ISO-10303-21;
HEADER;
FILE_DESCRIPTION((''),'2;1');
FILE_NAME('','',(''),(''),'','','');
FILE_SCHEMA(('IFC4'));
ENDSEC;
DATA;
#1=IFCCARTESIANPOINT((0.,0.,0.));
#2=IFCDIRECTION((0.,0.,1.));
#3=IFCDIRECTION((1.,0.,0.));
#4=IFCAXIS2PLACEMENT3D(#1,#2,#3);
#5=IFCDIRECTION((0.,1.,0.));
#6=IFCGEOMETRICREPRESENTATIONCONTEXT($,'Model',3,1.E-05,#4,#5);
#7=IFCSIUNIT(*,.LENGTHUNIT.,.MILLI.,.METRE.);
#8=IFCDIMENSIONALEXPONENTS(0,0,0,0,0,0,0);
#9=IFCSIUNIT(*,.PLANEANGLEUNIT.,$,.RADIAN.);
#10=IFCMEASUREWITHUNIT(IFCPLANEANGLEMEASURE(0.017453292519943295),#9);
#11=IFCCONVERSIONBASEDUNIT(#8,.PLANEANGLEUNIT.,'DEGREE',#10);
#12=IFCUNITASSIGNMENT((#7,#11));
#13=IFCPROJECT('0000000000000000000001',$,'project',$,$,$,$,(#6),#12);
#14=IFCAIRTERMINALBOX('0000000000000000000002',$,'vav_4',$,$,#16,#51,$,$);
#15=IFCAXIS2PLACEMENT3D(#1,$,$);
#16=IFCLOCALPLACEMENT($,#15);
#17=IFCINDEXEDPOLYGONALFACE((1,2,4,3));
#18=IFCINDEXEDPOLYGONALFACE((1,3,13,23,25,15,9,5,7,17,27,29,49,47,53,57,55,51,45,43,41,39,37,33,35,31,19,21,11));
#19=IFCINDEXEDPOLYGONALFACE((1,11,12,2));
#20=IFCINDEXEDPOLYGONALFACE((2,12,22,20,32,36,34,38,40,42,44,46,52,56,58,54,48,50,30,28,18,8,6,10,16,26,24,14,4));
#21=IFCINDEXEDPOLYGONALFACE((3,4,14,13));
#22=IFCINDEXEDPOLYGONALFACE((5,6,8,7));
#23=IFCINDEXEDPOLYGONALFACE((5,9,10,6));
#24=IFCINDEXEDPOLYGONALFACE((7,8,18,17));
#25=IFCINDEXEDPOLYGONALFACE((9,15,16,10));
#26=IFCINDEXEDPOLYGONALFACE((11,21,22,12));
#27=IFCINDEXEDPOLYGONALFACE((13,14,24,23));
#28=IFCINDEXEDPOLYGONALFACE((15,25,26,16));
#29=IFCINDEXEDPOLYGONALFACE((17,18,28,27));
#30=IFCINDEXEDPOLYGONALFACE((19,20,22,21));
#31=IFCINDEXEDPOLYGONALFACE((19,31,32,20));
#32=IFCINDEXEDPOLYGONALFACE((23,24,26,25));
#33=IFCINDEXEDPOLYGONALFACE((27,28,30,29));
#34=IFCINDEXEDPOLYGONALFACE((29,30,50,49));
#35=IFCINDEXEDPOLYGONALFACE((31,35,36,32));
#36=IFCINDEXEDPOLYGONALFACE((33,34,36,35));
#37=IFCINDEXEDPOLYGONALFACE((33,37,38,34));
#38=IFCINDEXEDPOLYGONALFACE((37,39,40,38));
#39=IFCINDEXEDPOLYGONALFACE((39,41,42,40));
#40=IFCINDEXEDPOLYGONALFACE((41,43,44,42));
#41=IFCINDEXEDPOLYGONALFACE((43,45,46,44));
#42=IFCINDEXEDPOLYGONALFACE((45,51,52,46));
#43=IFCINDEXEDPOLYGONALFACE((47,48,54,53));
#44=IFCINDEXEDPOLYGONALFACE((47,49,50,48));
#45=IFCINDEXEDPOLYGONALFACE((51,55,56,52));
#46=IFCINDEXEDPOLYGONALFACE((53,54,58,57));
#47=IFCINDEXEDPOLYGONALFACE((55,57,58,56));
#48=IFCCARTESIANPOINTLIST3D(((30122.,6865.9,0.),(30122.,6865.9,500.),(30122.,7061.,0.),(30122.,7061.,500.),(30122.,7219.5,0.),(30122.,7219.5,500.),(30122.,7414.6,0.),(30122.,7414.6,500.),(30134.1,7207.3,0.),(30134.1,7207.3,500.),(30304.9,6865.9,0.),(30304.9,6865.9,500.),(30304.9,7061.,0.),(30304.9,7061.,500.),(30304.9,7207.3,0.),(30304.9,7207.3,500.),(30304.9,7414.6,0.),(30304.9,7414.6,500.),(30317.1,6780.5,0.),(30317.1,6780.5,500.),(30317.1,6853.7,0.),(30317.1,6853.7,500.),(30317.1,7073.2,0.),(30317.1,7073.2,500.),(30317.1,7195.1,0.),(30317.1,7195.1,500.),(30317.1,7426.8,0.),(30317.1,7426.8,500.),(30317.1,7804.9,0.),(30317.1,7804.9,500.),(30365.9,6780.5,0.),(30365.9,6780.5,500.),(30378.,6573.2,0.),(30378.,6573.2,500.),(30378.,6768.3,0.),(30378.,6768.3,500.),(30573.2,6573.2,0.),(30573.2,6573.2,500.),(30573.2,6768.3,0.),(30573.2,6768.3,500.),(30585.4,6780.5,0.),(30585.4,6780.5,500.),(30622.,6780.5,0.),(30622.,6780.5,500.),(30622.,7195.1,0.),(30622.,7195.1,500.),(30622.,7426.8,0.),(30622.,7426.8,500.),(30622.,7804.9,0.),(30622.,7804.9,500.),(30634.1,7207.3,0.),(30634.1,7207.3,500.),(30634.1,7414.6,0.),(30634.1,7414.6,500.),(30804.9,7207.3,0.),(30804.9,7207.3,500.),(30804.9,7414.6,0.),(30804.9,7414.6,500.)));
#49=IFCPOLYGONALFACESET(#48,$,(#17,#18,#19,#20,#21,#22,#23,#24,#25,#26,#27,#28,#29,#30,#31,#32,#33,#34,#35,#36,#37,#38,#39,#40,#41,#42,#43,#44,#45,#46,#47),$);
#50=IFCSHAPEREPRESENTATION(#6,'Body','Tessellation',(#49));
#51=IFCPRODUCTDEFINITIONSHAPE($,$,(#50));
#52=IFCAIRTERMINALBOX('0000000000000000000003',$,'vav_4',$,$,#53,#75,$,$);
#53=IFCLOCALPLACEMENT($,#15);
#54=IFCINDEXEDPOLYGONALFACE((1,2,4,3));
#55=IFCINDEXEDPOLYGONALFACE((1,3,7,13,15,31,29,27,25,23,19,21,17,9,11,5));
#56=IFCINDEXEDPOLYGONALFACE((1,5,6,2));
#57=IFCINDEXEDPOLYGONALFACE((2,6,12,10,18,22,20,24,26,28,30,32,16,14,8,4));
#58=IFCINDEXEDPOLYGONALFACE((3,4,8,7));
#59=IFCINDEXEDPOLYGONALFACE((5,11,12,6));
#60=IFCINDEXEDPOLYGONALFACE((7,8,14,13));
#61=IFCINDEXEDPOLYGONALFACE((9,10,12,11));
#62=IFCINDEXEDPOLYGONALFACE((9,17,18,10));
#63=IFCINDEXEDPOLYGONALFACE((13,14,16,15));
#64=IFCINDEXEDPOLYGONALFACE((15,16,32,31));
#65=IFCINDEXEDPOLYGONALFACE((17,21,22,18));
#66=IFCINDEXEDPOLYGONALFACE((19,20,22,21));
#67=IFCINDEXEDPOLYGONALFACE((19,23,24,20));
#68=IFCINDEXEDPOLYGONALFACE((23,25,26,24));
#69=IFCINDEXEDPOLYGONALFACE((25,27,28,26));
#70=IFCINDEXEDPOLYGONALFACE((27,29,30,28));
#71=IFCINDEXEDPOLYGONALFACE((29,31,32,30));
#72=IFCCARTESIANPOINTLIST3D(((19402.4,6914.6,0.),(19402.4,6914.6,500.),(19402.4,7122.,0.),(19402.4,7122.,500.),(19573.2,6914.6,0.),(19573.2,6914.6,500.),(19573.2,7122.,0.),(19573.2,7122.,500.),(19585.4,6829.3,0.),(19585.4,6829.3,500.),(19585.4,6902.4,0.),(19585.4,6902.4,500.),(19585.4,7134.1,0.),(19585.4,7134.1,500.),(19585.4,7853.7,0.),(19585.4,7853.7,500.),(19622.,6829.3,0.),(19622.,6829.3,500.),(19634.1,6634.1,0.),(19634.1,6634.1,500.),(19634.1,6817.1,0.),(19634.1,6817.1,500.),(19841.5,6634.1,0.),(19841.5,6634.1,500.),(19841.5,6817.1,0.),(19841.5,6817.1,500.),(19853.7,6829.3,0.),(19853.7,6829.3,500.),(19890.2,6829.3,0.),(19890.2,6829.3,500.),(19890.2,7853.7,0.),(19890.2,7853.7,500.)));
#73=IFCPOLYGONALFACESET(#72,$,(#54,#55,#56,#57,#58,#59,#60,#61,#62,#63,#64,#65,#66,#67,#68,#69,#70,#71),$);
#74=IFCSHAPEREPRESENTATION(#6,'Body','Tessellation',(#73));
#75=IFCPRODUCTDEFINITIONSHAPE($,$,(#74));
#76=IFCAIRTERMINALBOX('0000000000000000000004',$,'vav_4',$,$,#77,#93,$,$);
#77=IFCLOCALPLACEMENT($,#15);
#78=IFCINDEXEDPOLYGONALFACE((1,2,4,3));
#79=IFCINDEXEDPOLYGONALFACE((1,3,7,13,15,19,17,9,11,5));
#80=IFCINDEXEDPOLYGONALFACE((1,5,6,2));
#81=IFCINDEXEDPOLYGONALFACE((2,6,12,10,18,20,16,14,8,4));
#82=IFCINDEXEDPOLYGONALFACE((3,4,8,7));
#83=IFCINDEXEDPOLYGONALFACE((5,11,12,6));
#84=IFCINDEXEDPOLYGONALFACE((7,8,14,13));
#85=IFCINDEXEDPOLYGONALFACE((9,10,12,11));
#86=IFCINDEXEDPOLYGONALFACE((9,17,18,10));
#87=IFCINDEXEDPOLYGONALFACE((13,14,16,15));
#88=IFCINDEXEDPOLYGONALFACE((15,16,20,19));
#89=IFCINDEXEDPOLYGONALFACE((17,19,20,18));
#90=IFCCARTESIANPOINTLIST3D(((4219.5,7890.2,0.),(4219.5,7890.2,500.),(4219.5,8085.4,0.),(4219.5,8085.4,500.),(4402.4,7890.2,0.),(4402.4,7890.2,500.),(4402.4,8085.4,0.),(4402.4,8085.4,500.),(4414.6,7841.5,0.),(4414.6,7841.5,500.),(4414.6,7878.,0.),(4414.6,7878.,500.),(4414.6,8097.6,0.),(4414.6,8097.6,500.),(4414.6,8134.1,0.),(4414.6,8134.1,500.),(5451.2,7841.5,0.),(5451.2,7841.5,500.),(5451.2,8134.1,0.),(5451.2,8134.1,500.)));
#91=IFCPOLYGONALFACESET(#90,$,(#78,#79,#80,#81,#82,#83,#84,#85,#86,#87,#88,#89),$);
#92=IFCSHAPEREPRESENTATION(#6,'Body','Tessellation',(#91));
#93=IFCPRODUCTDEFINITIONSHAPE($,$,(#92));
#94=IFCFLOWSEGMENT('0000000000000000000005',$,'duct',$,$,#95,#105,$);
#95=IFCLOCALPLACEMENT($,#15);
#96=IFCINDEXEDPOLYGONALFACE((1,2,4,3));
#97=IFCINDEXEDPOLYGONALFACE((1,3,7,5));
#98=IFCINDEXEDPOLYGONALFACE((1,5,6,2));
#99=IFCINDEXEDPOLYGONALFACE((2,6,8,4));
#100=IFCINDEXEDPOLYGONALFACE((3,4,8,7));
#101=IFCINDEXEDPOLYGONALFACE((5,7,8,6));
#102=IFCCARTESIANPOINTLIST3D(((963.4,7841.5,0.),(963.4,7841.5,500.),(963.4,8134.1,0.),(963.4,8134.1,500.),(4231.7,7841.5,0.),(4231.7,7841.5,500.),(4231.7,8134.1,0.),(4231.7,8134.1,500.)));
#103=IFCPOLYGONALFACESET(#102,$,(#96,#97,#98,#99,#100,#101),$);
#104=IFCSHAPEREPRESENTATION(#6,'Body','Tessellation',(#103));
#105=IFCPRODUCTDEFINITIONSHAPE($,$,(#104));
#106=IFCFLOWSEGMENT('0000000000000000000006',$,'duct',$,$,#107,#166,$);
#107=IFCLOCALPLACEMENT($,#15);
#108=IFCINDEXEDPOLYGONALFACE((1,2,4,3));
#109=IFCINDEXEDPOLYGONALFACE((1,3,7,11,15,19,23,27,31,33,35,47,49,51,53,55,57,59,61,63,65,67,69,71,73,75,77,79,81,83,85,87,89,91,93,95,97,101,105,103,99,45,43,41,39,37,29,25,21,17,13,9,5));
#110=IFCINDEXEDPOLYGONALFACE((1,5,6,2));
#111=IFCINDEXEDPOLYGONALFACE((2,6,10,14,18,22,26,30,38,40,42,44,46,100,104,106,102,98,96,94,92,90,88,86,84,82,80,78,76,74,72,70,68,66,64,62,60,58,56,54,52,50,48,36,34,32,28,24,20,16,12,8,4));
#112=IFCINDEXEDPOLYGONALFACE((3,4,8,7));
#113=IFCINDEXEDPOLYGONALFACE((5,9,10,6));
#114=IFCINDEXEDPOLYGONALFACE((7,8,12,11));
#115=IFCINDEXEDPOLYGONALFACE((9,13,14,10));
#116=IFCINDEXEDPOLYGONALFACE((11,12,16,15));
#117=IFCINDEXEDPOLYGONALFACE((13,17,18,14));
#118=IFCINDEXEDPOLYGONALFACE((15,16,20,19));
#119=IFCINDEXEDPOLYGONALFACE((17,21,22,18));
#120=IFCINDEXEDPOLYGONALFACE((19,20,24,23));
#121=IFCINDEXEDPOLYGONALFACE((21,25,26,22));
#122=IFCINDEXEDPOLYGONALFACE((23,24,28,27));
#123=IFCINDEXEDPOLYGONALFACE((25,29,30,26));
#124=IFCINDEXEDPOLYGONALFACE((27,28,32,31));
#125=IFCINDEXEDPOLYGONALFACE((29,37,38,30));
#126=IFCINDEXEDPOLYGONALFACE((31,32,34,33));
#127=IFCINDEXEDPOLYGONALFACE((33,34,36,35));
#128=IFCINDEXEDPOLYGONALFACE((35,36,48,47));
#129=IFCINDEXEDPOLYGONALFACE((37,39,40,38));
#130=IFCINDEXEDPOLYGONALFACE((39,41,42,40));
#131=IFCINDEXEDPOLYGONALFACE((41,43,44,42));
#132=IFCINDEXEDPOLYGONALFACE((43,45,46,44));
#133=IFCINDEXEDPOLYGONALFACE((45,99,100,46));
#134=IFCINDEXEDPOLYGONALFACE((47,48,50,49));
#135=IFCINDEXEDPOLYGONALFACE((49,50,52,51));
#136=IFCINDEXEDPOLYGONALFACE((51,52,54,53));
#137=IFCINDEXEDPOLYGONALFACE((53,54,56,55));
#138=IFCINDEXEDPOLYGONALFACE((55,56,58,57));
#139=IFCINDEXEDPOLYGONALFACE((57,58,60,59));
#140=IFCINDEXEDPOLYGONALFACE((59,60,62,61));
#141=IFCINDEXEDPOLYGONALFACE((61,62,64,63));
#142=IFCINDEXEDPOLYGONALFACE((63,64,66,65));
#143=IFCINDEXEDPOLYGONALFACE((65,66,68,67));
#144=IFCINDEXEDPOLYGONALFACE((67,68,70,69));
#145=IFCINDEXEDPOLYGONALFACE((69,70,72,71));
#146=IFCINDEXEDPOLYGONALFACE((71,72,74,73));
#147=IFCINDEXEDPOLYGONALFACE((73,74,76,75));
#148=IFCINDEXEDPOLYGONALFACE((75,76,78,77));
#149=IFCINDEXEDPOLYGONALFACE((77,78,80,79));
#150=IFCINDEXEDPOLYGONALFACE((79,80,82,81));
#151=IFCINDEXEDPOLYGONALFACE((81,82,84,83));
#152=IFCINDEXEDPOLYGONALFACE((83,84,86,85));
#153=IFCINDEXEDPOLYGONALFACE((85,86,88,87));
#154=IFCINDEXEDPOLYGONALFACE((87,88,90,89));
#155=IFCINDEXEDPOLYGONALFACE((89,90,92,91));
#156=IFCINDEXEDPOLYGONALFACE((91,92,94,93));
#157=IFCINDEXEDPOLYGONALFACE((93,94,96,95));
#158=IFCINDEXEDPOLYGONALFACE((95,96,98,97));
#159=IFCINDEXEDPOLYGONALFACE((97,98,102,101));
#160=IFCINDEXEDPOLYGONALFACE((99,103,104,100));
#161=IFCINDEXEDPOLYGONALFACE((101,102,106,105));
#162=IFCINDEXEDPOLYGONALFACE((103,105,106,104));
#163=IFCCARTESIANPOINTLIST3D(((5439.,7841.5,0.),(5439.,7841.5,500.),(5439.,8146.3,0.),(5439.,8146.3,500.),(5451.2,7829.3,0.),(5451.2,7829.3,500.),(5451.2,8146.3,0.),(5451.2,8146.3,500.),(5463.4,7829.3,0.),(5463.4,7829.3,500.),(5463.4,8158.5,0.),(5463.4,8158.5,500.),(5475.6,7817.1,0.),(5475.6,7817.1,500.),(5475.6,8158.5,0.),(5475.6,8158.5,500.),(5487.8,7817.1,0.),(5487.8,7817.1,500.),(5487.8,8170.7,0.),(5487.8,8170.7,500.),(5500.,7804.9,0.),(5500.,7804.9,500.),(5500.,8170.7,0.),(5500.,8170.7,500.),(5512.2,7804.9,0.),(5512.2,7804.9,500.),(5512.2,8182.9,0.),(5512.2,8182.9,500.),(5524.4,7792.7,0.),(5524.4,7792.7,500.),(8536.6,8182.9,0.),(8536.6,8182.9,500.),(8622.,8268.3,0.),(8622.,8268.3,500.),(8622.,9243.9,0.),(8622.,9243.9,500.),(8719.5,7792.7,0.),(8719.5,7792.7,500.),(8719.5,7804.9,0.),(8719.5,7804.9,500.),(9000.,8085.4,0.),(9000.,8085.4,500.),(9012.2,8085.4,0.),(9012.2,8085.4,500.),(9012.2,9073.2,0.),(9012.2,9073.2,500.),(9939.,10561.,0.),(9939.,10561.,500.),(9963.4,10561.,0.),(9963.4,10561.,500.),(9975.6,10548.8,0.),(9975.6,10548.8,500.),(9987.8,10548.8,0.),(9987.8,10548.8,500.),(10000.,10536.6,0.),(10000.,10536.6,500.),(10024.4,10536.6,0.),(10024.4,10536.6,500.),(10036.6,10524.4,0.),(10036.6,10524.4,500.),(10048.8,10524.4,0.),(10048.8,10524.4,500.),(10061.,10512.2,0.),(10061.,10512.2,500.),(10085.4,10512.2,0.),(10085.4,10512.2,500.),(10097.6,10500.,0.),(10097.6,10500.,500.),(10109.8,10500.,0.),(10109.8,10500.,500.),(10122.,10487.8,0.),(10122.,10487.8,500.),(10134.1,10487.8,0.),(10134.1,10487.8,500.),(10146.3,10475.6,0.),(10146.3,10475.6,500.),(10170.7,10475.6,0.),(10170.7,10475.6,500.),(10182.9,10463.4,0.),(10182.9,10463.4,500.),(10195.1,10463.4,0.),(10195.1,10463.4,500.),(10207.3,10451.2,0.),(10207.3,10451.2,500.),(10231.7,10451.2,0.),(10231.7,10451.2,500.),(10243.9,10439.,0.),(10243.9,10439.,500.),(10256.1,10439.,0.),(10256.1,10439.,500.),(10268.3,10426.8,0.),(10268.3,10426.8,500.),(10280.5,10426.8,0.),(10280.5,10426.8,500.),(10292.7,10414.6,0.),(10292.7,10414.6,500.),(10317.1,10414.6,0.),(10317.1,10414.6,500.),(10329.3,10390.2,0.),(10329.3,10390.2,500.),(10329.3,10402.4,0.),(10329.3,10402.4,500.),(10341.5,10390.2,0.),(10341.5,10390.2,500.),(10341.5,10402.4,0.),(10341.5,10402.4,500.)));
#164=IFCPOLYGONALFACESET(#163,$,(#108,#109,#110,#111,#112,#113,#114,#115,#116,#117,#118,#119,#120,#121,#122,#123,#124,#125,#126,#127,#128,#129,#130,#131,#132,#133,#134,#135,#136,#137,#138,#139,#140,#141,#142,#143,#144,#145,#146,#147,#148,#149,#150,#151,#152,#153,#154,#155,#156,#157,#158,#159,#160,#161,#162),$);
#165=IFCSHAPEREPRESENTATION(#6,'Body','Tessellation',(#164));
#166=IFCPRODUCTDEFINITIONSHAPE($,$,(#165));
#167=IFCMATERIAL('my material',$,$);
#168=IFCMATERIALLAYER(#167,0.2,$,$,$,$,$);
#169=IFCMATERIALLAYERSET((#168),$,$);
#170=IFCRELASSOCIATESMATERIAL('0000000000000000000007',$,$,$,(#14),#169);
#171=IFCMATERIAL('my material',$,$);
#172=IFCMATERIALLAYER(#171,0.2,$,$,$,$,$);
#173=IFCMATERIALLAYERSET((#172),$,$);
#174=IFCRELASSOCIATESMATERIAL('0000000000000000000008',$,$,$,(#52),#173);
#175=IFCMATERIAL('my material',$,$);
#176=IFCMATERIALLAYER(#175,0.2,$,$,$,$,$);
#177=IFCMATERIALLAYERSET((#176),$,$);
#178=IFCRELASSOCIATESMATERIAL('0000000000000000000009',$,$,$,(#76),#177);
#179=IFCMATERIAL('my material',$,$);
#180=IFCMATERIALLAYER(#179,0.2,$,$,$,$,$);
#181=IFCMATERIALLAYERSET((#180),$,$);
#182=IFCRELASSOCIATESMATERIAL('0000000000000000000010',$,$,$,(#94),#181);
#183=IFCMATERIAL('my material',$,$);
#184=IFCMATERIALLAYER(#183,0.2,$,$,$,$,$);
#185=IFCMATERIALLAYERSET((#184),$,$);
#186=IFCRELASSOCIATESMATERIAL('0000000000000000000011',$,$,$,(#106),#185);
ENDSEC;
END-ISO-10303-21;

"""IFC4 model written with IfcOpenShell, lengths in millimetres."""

from ifc_helpers import new_model, entity, si_unit, converted_unit, direction, origin_with_axes, place, context, project, polyline, outline, extrude, material, layer, layer_set, layer_usage, element, save


model = new_model("IFC4")

# Units and contexts
model_context = context("Model", 3, precision=1e-05, world=origin_with_axes(), true_north=direction((0.0, 1.0, 0.0)))
ifc_project = project(units=[si_unit("LENGTHUNIT", "METRE", prefix="MILLI"), converted_unit("PLANEANGLEUNIT", "DEGREE", entity("IfcPlaneAngleMeasure", 0.017453292519943295), si_unit("PLANEANGLEUNIT", "RADIAN"), dimensions=[0, 0, 0, 0, 0, 0, 0])], contexts=[model_context])

# Air terminal boxes
ifc_material_1 = material(Name="my material")
ifc_layer_1 = layer(ifc_material_1, 0.2)
ifc_layer_set_1 = layer_set([ifc_layer_1])
ifc_layer_usage_1 = layer_usage(ifc_layer_set_1, "AXIS2", "POSITIVE", -0.1)
air_terminal_box_1_placement = place(None, origin_with_axes())
element("IfcAirTerminalBox", 1, at=air_terminal_box_1_placement, material=ifc_layer_usage_1, Name="vav_4", context=model_context, shape_type="SweptSolid", body=[
    extrude(outline(polyline([(30122.0, 6865.9), (30304.9, 6865.9), (30317.1, 6853.7), (30317.1, 6780.5), (30365.9, 6780.5), (30378.0, 6768.3), (30378.0, 6573.2), (30573.2, 6573.2), (30573.2, 6768.3), (30585.4, 6780.5), (30622.0, 6780.5), (30622.0, 7195.1), (30634.1, 7207.3), (30804.9, 7207.3), (30804.9, 7414.6), (30634.1, 7414.6), (30622.0, 7426.8), (30622.0, 7804.9), (30317.1, 7804.9), (30317.1, 7426.8), (30304.9, 7414.6), (30122.0, 7414.6), (30122.0, 7219.5), (30134.1, 7207.3), (30304.9, 7207.3), (30317.1, 7195.1), (30317.1, 7073.2), (30304.9, 7061.0), (30122.0, 7061.0), (30122.0, 6865.9)])), origin_with_axes(), (0.0, 0.0, 1.0), 500.0),
])
ifc_material_2 = material(Name="my material")
ifc_layer_2 = layer(ifc_material_2, 0.2)
ifc_layer_set_2 = layer_set([ifc_layer_2])
ifc_layer_usage_2 = layer_usage(ifc_layer_set_2, "AXIS2", "POSITIVE", -0.1)
air_terminal_box_2_placement = place(None, origin_with_axes())
element("IfcAirTerminalBox", 2, at=air_terminal_box_2_placement, material=ifc_layer_usage_2, Name="vav_4", context=model_context, shape_type="SweptSolid", body=[
    extrude(outline(polyline([(19402.4, 6914.6), (19573.2, 6914.6), (19585.4, 6902.4), (19585.4, 6829.3), (19622.0, 6829.3), (19634.1, 6817.1), (19634.1, 6634.1), (19841.5, 6634.1), (19841.5, 6817.1), (19853.7, 6829.3), (19890.2, 6829.3), (19890.2, 7853.7), (19585.4, 7853.7), (19585.4, 7134.1), (19573.2, 7122.0), (19402.4, 7122.0), (19402.4, 6914.6)])), origin_with_axes(), (0.0, 0.0, 1.0), 500.0),
])
ifc_material_3 = material(Name="my material")
ifc_layer_3 = layer(ifc_material_3, 0.2)
ifc_layer_set_3 = layer_set([ifc_layer_3])
ifc_layer_usage_3 = layer_usage(ifc_layer_set_3, "AXIS2", "POSITIVE", -0.1)
air_terminal_box_3_placement = place(None, origin_with_axes())
element("IfcAirTerminalBox", 3, at=air_terminal_box_3_placement, material=ifc_layer_usage_3, Name="vav_4", context=model_context, shape_type="SweptSolid", body=[
    extrude(outline(polyline([(4219.5, 7890.2), (4402.4, 7890.2), (4414.6, 7878.0), (4414.6, 7841.5), (5451.2, 7841.5), (5451.2, 8134.1), (4414.6, 8134.1), (4414.6, 8097.6), (4402.4, 8085.4), (4219.5, 8085.4), (4219.5, 7890.2)])), origin_with_axes(), (0.0, 0.0, 1.0), 500.0),
])

# Flow segments
ifc_material_4 = material(Name="my material")
ifc_layer_4 = layer(ifc_material_4, 0.2)
ifc_layer_set_4 = layer_set([ifc_layer_4])
ifc_layer_usage_4 = layer_usage(ifc_layer_set_4, "AXIS2", "POSITIVE", -0.1)
flow_segment_1_placement = place(None, origin_with_axes())
element("IfcFlowSegment", 4, at=flow_segment_1_placement, material=ifc_layer_usage_4, Name="duct", context=model_context, shape_type="SweptSolid", body=[
    extrude(outline(polyline([(963.4, 7841.5), (4231.7, 7841.5), (4231.7, 8134.1), (963.4, 8134.1), (963.4, 7841.5)])), origin_with_axes(), (0.0, 0.0, 1.0), 500.0),
])
ifc_material_5 = material(Name="my material")
ifc_layer_5 = layer(ifc_material_5, 0.2)
ifc_layer_set_5 = layer_set([ifc_layer_5])
ifc_layer_usage_5 = layer_usage(ifc_layer_set_5, "AXIS2", "POSITIVE", -0.1)
flow_segment_2_placement = place(None, origin_with_axes())
element("IfcFlowSegment", 5, at=flow_segment_2_placement, material=ifc_layer_usage_5, Name="duct", context=model_context, shape_type="SweptSolid", body=[
    extrude(outline(polyline([(5439.0, 7841.5), (5451.2, 7829.3), (5463.4, 7829.3), (5475.6, 7817.1), (5487.8, 7817.1), (5500.0, 7804.9), (5512.2, 7804.9), (5524.4, 7792.7), (8719.5, 7792.7), (8719.5, 7804.9), (9000.0, 8085.4), (9012.2, 8085.4), (9012.2, 9073.2), (10329.3, 10390.2), (10341.5, 10390.2), (10341.5, 10402.4), (10329.3, 10402.4), (10317.1, 10414.6), (10292.7, 10414.6), (10280.5, 10426.8), (10268.3, 10426.8), (10256.1, 10439.0), (10243.9, 10439.0), (10231.7, 10451.2), (10207.3, 10451.2), (10195.1, 10463.4), (10182.9, 10463.4), (10170.7, 10475.6), (10146.3, 10475.6), (10134.1, 10487.8), (10122.0, 10487.8), (10109.8, 10500.0), (10097.6, 10500.0), (10085.4, 10512.2), (10061.0, 10512.2), (10048.8, 10524.4), (10036.6, 10524.4), (10024.4, 10536.6), (10000.0, 10536.6), (9987.8, 10548.8), (9975.6, 10548.8), (9963.4, 10561.0), (9939.0, 10561.0), (8622.0, 9243.9), (8622.0, 8268.3), (8536.6, 8182.9), (5512.2, 8182.9), (5500.0, 8170.7), (5487.8, 8170.7), (5475.6, 8158.5), (5463.4, 8158.5), (5451.2, 8146.3), (5439.0, 8146.3), (5439.0, 7841.5)])), origin_with_axes(), (0.0, 0.0, 1.0), 500.0),
])

save(model, "model.ifc")
